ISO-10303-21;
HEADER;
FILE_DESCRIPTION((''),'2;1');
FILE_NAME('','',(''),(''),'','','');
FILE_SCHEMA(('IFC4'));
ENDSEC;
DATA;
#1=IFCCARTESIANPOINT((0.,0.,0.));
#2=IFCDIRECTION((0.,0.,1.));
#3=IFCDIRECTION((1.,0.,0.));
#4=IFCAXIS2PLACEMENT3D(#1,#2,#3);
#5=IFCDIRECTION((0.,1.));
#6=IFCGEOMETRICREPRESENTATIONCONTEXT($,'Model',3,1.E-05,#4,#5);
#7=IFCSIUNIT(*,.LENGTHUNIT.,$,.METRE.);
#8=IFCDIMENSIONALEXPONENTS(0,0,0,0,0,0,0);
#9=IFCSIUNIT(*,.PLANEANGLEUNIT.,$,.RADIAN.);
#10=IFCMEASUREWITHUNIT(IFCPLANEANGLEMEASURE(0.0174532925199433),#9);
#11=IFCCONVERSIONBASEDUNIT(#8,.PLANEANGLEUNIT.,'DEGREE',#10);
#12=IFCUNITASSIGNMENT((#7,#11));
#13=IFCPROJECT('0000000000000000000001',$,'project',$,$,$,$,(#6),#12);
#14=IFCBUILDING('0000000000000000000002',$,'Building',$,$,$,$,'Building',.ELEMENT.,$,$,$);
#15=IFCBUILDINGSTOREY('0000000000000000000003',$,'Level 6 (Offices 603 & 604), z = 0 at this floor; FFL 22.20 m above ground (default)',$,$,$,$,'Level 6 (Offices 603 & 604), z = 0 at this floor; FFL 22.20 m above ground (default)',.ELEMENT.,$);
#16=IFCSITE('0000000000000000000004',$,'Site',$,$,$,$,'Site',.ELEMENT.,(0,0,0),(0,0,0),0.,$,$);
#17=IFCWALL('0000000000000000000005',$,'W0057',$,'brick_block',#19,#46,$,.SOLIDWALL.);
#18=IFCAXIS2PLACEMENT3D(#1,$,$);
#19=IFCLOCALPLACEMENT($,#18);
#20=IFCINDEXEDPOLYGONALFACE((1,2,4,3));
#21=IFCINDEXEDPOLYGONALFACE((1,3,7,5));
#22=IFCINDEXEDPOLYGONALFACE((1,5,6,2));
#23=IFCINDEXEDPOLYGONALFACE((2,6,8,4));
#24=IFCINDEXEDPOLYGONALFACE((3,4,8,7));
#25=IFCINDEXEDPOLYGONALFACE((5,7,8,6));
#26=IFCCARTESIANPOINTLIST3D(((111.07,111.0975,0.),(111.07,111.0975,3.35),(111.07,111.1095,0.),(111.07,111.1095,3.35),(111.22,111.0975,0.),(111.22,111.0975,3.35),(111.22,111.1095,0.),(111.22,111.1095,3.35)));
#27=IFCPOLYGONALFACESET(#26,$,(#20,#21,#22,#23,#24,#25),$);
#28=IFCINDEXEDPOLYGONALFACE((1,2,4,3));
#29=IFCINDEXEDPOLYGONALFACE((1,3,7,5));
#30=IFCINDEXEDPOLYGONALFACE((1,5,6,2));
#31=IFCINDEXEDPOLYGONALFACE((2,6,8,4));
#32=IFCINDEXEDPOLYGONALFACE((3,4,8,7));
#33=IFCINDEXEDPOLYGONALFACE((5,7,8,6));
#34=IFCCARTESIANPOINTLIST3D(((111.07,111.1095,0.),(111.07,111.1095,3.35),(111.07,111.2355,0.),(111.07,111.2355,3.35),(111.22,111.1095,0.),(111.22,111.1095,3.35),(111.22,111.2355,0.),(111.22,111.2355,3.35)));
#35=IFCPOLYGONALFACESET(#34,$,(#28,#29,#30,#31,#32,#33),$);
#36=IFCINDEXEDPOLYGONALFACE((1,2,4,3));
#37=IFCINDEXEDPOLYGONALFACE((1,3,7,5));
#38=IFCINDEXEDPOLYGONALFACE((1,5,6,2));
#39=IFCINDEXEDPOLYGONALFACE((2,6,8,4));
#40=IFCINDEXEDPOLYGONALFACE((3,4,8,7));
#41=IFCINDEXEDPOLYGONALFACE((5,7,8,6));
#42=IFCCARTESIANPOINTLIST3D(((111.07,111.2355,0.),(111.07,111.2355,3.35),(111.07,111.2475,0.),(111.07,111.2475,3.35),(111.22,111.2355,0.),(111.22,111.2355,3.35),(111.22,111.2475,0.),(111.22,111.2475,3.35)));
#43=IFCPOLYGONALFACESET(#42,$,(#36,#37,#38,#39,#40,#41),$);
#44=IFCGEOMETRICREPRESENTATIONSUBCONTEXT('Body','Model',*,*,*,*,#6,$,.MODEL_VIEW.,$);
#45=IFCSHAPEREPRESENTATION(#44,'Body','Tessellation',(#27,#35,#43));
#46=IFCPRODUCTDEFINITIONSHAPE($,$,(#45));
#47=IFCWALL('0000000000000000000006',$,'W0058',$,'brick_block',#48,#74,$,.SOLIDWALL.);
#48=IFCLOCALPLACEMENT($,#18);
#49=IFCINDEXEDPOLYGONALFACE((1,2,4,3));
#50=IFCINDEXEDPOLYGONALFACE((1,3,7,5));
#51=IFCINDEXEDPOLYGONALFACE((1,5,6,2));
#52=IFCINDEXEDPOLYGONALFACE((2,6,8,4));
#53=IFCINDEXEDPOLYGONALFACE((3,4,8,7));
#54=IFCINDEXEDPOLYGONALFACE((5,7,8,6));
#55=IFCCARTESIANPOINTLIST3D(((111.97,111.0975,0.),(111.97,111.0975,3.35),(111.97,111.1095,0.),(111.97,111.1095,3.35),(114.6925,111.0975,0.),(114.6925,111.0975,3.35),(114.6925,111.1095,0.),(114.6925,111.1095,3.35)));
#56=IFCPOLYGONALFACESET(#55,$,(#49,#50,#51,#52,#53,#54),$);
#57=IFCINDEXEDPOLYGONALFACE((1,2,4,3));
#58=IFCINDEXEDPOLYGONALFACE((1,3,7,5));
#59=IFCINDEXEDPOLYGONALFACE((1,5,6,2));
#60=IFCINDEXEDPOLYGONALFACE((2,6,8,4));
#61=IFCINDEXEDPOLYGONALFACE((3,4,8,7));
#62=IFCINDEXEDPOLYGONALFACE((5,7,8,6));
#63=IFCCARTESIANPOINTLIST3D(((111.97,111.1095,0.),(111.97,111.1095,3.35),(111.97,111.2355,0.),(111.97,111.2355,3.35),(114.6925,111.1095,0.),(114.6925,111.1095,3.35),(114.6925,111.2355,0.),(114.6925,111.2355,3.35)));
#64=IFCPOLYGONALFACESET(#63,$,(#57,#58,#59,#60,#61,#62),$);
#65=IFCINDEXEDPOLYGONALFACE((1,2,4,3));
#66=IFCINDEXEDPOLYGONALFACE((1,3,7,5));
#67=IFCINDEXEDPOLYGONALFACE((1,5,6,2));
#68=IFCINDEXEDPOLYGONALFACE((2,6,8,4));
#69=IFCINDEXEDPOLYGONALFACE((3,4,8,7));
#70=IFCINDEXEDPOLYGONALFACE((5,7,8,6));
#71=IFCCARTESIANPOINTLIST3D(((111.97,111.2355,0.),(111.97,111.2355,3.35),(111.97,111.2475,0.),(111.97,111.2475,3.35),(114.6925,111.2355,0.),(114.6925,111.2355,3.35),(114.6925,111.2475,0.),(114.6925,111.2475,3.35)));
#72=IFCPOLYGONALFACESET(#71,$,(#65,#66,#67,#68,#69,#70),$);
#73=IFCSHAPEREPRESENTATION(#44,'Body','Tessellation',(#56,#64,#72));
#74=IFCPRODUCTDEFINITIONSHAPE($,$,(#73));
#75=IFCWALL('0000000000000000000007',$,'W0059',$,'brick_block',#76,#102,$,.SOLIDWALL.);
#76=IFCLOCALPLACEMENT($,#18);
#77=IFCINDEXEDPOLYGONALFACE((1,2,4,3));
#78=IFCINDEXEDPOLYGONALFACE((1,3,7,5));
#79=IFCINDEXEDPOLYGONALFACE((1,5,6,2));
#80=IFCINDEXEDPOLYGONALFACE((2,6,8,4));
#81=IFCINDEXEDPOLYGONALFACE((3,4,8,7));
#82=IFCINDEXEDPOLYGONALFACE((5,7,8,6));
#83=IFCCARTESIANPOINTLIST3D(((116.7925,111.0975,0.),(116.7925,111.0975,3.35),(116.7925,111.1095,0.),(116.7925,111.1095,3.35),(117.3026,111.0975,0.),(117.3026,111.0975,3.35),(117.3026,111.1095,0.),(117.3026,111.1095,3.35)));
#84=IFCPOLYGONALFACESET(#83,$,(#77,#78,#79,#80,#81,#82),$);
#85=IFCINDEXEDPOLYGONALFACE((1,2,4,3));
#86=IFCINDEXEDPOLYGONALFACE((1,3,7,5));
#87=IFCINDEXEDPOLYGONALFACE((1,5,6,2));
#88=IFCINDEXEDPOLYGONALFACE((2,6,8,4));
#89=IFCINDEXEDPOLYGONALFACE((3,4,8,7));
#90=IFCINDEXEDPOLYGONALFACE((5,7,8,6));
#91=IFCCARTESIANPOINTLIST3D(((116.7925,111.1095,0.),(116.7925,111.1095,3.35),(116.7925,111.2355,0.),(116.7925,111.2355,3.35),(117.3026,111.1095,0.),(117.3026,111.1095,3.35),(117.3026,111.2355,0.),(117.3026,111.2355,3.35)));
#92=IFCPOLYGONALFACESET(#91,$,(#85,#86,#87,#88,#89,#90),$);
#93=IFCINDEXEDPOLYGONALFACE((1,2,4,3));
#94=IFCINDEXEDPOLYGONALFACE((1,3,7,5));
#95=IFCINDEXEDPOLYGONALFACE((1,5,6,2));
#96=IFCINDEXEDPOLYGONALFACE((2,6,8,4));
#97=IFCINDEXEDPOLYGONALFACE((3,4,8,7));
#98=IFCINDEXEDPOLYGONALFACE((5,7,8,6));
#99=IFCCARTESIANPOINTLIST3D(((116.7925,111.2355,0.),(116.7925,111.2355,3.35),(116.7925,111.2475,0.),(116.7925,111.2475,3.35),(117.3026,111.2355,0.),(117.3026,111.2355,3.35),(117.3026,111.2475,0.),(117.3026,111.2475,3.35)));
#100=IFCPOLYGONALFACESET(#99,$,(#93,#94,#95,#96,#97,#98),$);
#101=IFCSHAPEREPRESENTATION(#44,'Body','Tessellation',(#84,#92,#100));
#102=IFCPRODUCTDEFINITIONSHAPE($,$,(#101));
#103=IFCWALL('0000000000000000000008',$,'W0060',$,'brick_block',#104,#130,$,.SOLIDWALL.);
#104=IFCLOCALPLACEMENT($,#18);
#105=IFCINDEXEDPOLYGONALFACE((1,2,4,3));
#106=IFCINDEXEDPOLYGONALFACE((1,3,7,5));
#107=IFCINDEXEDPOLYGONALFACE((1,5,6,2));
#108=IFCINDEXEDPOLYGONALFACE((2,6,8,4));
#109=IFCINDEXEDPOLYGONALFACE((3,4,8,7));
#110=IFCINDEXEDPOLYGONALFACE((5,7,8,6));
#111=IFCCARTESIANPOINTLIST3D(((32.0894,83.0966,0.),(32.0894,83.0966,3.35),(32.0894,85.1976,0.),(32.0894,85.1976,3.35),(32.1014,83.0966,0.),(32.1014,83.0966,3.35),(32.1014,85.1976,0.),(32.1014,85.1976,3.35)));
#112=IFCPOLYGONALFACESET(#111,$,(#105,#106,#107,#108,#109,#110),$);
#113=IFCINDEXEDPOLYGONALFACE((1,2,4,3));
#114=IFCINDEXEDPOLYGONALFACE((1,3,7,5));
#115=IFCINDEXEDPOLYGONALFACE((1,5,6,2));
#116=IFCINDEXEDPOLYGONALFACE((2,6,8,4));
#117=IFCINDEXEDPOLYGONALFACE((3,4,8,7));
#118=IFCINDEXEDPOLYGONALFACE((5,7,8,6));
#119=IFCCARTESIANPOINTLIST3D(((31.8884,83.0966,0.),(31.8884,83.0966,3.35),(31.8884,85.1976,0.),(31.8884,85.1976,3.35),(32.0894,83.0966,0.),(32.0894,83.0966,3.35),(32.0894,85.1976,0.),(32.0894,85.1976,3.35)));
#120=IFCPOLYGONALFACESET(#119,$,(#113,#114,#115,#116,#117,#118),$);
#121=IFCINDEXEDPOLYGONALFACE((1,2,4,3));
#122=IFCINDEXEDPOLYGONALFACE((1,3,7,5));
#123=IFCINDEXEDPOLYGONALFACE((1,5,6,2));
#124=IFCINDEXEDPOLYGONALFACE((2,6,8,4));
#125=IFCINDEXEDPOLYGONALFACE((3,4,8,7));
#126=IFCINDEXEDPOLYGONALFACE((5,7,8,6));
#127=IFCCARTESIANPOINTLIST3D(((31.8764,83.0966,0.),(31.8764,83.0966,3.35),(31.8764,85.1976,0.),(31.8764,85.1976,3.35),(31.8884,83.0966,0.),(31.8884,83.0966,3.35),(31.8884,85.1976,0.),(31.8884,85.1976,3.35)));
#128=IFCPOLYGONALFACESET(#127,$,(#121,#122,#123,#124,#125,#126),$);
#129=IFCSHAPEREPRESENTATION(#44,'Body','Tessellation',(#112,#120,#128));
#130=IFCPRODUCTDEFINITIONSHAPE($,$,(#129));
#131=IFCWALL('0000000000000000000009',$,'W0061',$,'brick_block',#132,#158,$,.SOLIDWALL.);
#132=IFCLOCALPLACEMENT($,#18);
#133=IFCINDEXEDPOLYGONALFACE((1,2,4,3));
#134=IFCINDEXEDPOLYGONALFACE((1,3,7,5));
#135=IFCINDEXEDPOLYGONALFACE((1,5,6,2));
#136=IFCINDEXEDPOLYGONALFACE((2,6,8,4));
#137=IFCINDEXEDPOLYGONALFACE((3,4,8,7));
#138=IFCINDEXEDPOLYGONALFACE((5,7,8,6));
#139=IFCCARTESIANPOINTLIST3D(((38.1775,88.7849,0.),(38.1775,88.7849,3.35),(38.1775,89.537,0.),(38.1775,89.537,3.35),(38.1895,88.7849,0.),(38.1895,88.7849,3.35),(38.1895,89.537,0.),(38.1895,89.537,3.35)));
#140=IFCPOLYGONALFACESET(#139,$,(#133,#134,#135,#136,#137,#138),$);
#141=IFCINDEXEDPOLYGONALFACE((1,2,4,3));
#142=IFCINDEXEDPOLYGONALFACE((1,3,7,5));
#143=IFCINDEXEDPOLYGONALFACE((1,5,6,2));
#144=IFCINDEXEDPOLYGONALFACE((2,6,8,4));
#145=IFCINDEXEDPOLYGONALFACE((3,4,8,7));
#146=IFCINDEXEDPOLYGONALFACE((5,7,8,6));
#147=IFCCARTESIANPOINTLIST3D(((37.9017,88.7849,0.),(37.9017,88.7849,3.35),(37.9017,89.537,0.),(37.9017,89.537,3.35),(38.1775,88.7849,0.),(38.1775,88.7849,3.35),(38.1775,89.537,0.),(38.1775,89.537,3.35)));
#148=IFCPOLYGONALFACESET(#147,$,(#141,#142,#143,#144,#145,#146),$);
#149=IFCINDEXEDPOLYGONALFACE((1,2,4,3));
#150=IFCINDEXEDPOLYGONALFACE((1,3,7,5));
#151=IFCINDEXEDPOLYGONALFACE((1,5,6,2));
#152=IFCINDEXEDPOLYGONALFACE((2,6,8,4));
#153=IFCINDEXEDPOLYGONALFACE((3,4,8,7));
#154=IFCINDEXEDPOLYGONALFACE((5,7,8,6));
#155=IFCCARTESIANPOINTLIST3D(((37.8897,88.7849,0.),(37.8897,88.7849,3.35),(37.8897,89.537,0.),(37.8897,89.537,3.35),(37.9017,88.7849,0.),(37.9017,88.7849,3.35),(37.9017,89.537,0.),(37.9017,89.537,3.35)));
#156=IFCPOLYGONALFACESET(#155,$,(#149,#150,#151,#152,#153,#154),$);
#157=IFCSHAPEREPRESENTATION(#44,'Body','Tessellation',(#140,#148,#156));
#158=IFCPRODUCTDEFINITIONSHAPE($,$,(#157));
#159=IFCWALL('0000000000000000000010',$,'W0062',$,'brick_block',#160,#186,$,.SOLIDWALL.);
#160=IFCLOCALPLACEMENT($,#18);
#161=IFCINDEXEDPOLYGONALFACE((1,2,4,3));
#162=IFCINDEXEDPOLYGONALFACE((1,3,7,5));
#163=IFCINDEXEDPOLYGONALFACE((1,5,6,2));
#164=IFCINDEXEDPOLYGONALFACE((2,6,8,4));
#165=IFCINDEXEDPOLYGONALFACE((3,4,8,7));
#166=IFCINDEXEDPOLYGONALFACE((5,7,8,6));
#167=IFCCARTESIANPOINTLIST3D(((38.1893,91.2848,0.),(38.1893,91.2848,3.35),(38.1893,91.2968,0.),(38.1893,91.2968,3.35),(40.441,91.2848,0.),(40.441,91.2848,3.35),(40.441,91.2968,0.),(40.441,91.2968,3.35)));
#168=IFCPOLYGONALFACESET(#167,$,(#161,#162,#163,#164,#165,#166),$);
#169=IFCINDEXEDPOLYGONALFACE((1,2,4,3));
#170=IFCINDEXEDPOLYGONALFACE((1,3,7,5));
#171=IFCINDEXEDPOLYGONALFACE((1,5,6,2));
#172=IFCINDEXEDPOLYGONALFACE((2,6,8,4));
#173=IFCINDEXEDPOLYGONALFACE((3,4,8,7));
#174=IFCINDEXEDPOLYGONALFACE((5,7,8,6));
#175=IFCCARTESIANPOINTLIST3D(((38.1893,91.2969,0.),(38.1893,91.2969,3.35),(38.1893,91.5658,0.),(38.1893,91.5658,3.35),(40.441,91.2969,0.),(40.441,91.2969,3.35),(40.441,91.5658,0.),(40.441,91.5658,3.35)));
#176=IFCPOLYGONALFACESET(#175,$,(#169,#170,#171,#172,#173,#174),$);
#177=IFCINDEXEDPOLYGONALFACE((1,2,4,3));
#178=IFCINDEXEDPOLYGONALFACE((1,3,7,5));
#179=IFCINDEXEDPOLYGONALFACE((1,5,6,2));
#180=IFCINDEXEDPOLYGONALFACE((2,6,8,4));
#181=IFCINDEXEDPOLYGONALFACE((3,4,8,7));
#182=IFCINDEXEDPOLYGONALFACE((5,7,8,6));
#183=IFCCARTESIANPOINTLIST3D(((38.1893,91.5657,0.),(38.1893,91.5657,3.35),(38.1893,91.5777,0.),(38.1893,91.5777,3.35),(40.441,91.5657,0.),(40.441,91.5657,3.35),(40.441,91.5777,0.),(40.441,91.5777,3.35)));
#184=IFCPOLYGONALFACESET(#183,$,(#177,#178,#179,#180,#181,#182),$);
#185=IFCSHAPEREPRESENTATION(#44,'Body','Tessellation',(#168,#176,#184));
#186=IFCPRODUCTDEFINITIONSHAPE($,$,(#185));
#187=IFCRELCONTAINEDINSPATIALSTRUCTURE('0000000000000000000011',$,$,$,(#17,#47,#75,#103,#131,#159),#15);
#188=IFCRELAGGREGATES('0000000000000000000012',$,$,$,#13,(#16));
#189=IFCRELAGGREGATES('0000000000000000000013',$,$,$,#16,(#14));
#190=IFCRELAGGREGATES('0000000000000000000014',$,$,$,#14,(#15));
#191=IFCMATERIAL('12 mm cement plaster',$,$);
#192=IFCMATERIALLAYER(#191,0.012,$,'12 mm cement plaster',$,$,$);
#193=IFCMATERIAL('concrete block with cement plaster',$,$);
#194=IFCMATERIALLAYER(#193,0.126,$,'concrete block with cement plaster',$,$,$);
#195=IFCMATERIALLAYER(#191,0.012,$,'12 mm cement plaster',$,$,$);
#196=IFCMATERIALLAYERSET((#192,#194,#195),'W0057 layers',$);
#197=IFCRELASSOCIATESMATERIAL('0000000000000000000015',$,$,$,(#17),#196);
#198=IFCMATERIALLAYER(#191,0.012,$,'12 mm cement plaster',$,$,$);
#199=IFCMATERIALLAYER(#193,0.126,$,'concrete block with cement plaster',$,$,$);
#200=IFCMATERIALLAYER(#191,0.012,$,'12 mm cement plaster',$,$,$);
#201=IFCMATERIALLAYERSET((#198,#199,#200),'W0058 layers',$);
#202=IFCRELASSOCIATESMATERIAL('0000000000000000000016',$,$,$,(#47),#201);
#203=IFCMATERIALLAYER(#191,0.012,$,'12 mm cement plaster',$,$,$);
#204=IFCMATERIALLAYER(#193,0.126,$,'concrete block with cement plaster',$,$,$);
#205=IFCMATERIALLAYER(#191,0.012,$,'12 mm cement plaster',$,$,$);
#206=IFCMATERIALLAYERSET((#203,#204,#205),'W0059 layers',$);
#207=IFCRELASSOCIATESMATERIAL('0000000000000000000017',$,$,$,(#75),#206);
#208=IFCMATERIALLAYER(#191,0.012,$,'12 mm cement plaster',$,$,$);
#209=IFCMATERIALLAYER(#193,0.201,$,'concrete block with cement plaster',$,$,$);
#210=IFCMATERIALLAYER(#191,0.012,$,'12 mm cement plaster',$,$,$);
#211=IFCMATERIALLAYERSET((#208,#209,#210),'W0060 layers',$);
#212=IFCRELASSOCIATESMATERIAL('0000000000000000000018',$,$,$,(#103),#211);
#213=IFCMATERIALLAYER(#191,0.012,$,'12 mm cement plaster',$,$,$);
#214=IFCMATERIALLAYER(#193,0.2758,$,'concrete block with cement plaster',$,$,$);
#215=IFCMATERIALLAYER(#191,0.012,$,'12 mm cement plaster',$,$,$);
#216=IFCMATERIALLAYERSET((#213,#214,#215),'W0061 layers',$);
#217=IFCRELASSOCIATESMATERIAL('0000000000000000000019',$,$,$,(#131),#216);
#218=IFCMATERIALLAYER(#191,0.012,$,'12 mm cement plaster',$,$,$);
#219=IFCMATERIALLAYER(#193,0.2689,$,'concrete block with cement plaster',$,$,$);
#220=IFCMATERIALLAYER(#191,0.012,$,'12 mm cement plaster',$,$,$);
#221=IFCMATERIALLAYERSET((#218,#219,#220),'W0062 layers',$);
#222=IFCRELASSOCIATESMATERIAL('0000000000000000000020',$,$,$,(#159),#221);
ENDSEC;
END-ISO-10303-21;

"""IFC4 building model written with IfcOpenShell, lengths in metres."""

from ifc_helpers import new_model, entity, si_unit, converted_unit, direction, frame, frame_2d, origin_with_axes, origin_2d_with_axis, place, context, subcontext, project, spatial, rectangle, extrude, material, layer, layer_set, layer_usage, element, save


model = new_model("IFC4")

# Units and contexts
model_context = context("Model", 3, precision=1e-05, world=origin_with_axes(), true_north=direction((0.0, 1.0)))
body_context = subcontext(model_context, "Body", "Model", "MODEL_VIEW")
ifc_project = project(units=[si_unit("LENGTHUNIT", "METRE"), converted_unit("PLANEANGLEUNIT", "DEGREE", entity("IfcPlaneAngleMeasure", 0.0174532925199433), si_unit("PLANEANGLEUNIT", "RADIAN"), dimensions=[0, 0, 0, 0, 0, 0, 0])], contexts=[model_context])

# Site, building, storey
site = spatial("IfcSite", under=ifc_project, Name="Site", LongName="Site", CompositionType="ELEMENT", RefLatitude=(0, 0, 0), RefLongitude=(0, 0, 0), RefElevation=0.0)
building = spatial("IfcBuilding", under=site, Name="Building", LongName="Building", CompositionType="ELEMENT")
storey = spatial("IfcBuildingStorey", under=building, Name="Level 6 (Offices 603 & 604), z = 0 at this floor; FFL 22.20 m above ground (default)", LongName="Level 6 (Offices 603 & 604), z = 0 at this floor; FFL 22.20 m above ground (default)", CompositionType="ELEMENT")

# Walls
ifc_material_1 = material(Name="12 mm cement plaster")
ifc_material_2 = material(Name="concrete block with cement plaster")
placement = place(None, origin_with_axes())
ifc_layer_1 = layer(ifc_material_1, 0.012, Name="12 mm cement plaster")
ifc_layer_2 = layer(ifc_material_2, 0.126, Name="concrete block with cement plaster")
ifc_layer_3 = layer(ifc_material_1, 0.012, Name="12 mm cement plaster")
ifc_layer_set_1 = layer_set([ifc_layer_1, ifc_layer_2, ifc_layer_3], Name="W0057 layers")
ifc_layer_usage_1 = layer_usage(ifc_layer_set_1, "AXIS2", "POSITIVE", -0.075)
element("IfcWall", 1, at=placement, inside=storey, material=ifc_layer_usage_1, Name="W0057", ObjectType="brick_block", PredefinedType="SOLIDWALL", context=body_context, shape_type="SweptSolid", body=[
    extrude(rectangle(XDim=0.15, YDim=0.012, at=frame_2d((0.0, 0.0), x_axis=(1.0, 0.0))), frame((111.145, 111.1035, 0.0), z_axis=(0.0, 0.0, 1.0), x_axis=(1.0, 0.0, 0.0)), (0.0, 0.0, 1.0), 3.35),
    extrude(rectangle(XDim=0.15, YDim=0.126, at=frame_2d((0.0, 0.069), x_axis=(1.0, 0.0))), frame((111.145, 111.1035, 0.0), z_axis=(0.0, 0.0, 1.0), x_axis=(1.0, 0.0, 0.0)), (0.0, 0.0, 1.0), 3.35),
    extrude(rectangle(XDim=0.15, YDim=0.012, at=frame_2d((0.0, 0.138), x_axis=(1.0, 0.0))), frame((111.145, 111.1035, 0.0), z_axis=(0.0, 0.0, 1.0), x_axis=(1.0, 0.0, 0.0)), (0.0, 0.0, 1.0), 3.35),
])
ifc_layer_4 = layer(ifc_material_1, 0.012, Name="12 mm cement plaster")
ifc_layer_5 = layer(ifc_material_2, 0.126, Name="concrete block with cement plaster")
ifc_layer_6 = layer(ifc_material_1, 0.012, Name="12 mm cement plaster")
ifc_layer_set_2 = layer_set([ifc_layer_4, ifc_layer_5, ifc_layer_6], Name="W0058 layers")
ifc_layer_usage_2 = layer_usage(ifc_layer_set_2, "AXIS2", "POSITIVE", -0.075)
element("IfcWall", 2, at=placement, inside=storey, material=ifc_layer_usage_2, Name="W0058", ObjectType="brick_block", PredefinedType="SOLIDWALL", context=body_context, shape_type="SweptSolid", body=[
    extrude(rectangle(XDim=2.7225, YDim=0.012, at=frame_2d((0.0, 0.0), x_axis=(1.0, 0.0))), frame((113.3312, 111.1035, 0.0), z_axis=(0.0, 0.0, 1.0), x_axis=(1.0, 0.0, 0.0)), (0.0, 0.0, 1.0), 3.35),
    extrude(rectangle(XDim=2.7225, YDim=0.126, at=frame_2d((0.0, 0.069), x_axis=(1.0, 0.0))), frame((113.3312, 111.1035, 0.0), z_axis=(0.0, 0.0, 1.0), x_axis=(1.0, 0.0, 0.0)), (0.0, 0.0, 1.0), 3.35),
    extrude(rectangle(XDim=2.7225, YDim=0.012, at=frame_2d((0.0, 0.138), x_axis=(1.0, 0.0))), frame((113.3312, 111.1035, 0.0), z_axis=(0.0, 0.0, 1.0), x_axis=(1.0, 0.0, 0.0)), (0.0, 0.0, 1.0), 3.35),
])
ifc_layer_7 = layer(ifc_material_1, 0.012, Name="12 mm cement plaster")
ifc_layer_8 = layer(ifc_material_2, 0.126, Name="concrete block with cement plaster")
ifc_layer_9 = layer(ifc_material_1, 0.012, Name="12 mm cement plaster")
ifc_layer_set_3 = layer_set([ifc_layer_7, ifc_layer_8, ifc_layer_9], Name="W0059 layers")
ifc_layer_usage_3 = layer_usage(ifc_layer_set_3, "AXIS2", "POSITIVE", -0.075)
element("IfcWall", 3, at=placement, inside=storey, material=ifc_layer_usage_3, Name="W0059", ObjectType="brick_block", PredefinedType="SOLIDWALL", context=body_context, shape_type="SweptSolid", body=[
    extrude(rectangle(XDim=0.5101, YDim=0.012, at=origin_2d_with_axis()), frame((117.0476, 111.1035, 0.0), z_axis=(0.0, 0.0, 1.0), x_axis=(1.0, 0.0, 0.0)), (0.0, 0.0, 1.0), 3.35),
    extrude(rectangle(XDim=0.5101, YDim=0.126, at=frame_2d((0.0, 0.069), x_axis=(1.0, 0.0))), frame((117.0476, 111.1035, 0.0), z_axis=(0.0, 0.0, 1.0), x_axis=(1.0, 0.0, 0.0)), (0.0, 0.0, 1.0), 3.35),
    extrude(rectangle(XDim=0.5101, YDim=0.012, at=frame_2d((0.0, 0.138), x_axis=(1.0, 0.0))), frame((117.0476, 111.1035, 0.0), z_axis=(0.0, 0.0, 1.0), x_axis=(1.0, 0.0, 0.0)), (0.0, 0.0, 1.0), 3.35),
])
ifc_layer_10 = layer(ifc_material_1, 0.012, Name="12 mm cement plaster")
ifc_layer_11 = layer(ifc_material_2, 0.201, Name="concrete block with cement plaster")
ifc_layer_12 = layer(ifc_material_1, 0.012, Name="12 mm cement plaster")
ifc_layer_set_4 = layer_set([ifc_layer_10, ifc_layer_11, ifc_layer_12], Name="W0060 layers")
ifc_layer_usage_4 = layer_usage(ifc_layer_set_4, "AXIS2", "POSITIVE", -0.1125)
element("IfcWall", 4, at=placement, inside=storey, material=ifc_layer_usage_4, Name="W0060", ObjectType="brick_block", PredefinedType="SOLIDWALL", context=body_context, shape_type="SweptSolid", body=[
    extrude(rectangle(XDim=2.101, YDim=0.012, at=frame_2d((0.0, 0.0), x_axis=(0.0, 1.0))), frame((32.0954, 84.1471, 0.0), z_axis=(0.0, 0.0, 1.0), x_axis=(1.0, 0.0, 0.0)), (0.0, 0.0, 1.0), 3.35),
    extrude(rectangle(XDim=2.101, YDim=0.201, at=frame_2d((-0.1065, 0.0), x_axis=(0.0, 1.0))), frame((32.0954, 84.1471, 0.0), z_axis=(0.0, 0.0, 1.0), x_axis=(1.0, 0.0, 0.0)), (0.0, 0.0, 1.0), 3.35),
    extrude(rectangle(XDim=2.101, YDim=0.012, at=frame_2d((-0.213, 0.0), x_axis=(0.0, 1.0))), frame((32.0954, 84.1471, 0.0), z_axis=(0.0, 0.0, 1.0), x_axis=(1.0, 0.0, 0.0)), (0.0, 0.0, 1.0), 3.35),
])
ifc_layer_13 = layer(ifc_material_1, 0.012, Name="12 mm cement plaster")
ifc_layer_14 = layer(ifc_material_2, 0.2758, Name="concrete block with cement plaster")
ifc_layer_15 = layer(ifc_material_1, 0.012, Name="12 mm cement plaster")
ifc_layer_set_5 = layer_set([ifc_layer_13, ifc_layer_14, ifc_layer_15], Name="W0061 layers")
ifc_layer_usage_5 = layer_usage(ifc_layer_set_5, "AXIS2", "POSITIVE", -0.1499)
element("IfcWall", 5, at=placement, inside=storey, material=ifc_layer_usage_5, Name="W0061", ObjectType="brick_block", PredefinedType="SOLIDWALL", context=body_context, shape_type="SweptSolid", body=[
    extrude(rectangle(XDim=0.7521, YDim=0.012, at=frame_2d((0.0, 0.0), x_axis=(0.0, 1.0))), frame((38.1835, 89.1609, 0.0), z_axis=(0.0, 0.0, 1.0), x_axis=(1.0, 0.0, 0.0)), (0.0, 0.0, 1.0), 3.35),
    extrude(rectangle(XDim=0.7521, YDim=0.2758, at=frame_2d((-0.1439, 0.0), x_axis=(0.0, 1.0))), frame((38.1835, 89.1609, 0.0), z_axis=(0.0, 0.0, 1.0), x_axis=(1.0, 0.0, 0.0)), (0.0, 0.0, 1.0), 3.35),
    extrude(rectangle(XDim=0.7521, YDim=0.012, at=frame_2d((-0.2878, 0.0), x_axis=(0.0, 1.0))), frame((38.1835, 89.1609, 0.0), z_axis=(0.0, 0.0, 1.0), x_axis=(1.0, 0.0, 0.0)), (0.0, 0.0, 1.0), 3.35),
])
ifc_layer_16 = layer(ifc_material_1, 0.012, Name="12 mm cement plaster")
ifc_layer_17 = layer(ifc_material_2, 0.2689, Name="concrete block with cement plaster")
ifc_layer_18 = layer(ifc_material_1, 0.012, Name="12 mm cement plaster")
ifc_layer_set_6 = layer_set([ifc_layer_16, ifc_layer_17, ifc_layer_18], Name="W0062 layers")
ifc_layer_usage_6 = layer_usage(ifc_layer_set_6, "AXIS2", "POSITIVE", -0.1464)
element("IfcWall", 6, at=placement, inside=storey, material=ifc_layer_usage_6, Name="W0062", ObjectType="brick_block", PredefinedType="SOLIDWALL", context=body_context, shape_type="SweptSolid", body=[
    extrude(rectangle(XDim=2.2517, YDim=0.012, at=frame_2d((0.0, 0.0), x_axis=(1.0, 0.0))), frame((39.3152, 91.2909, 0.0), z_axis=(0.0, 0.0, 1.0), x_axis=(1.0, 0.0, 0.0)), (0.0, 0.0, 1.0), 3.35),
    extrude(rectangle(XDim=2.2517, YDim=0.2689, at=frame_2d((0.0, 0.1405), x_axis=(1.0, 0.0))), frame((39.3152, 91.2909, 0.0), z_axis=(0.0, 0.0, 1.0), x_axis=(1.0, 0.0, 0.0)), (0.0, 0.0, 1.0), 3.35),
    extrude(rectangle(XDim=2.2517, YDim=0.012, at=frame_2d((0.0, 0.2809), x_axis=(1.0, 0.0))), frame((39.3152, 91.2909, 0.0), z_axis=(0.0, 0.0, 1.0), x_axis=(1.0, 0.0, 0.0)), (0.0, 0.0, 1.0), 3.35),
])

save(model, "model.ifc")
